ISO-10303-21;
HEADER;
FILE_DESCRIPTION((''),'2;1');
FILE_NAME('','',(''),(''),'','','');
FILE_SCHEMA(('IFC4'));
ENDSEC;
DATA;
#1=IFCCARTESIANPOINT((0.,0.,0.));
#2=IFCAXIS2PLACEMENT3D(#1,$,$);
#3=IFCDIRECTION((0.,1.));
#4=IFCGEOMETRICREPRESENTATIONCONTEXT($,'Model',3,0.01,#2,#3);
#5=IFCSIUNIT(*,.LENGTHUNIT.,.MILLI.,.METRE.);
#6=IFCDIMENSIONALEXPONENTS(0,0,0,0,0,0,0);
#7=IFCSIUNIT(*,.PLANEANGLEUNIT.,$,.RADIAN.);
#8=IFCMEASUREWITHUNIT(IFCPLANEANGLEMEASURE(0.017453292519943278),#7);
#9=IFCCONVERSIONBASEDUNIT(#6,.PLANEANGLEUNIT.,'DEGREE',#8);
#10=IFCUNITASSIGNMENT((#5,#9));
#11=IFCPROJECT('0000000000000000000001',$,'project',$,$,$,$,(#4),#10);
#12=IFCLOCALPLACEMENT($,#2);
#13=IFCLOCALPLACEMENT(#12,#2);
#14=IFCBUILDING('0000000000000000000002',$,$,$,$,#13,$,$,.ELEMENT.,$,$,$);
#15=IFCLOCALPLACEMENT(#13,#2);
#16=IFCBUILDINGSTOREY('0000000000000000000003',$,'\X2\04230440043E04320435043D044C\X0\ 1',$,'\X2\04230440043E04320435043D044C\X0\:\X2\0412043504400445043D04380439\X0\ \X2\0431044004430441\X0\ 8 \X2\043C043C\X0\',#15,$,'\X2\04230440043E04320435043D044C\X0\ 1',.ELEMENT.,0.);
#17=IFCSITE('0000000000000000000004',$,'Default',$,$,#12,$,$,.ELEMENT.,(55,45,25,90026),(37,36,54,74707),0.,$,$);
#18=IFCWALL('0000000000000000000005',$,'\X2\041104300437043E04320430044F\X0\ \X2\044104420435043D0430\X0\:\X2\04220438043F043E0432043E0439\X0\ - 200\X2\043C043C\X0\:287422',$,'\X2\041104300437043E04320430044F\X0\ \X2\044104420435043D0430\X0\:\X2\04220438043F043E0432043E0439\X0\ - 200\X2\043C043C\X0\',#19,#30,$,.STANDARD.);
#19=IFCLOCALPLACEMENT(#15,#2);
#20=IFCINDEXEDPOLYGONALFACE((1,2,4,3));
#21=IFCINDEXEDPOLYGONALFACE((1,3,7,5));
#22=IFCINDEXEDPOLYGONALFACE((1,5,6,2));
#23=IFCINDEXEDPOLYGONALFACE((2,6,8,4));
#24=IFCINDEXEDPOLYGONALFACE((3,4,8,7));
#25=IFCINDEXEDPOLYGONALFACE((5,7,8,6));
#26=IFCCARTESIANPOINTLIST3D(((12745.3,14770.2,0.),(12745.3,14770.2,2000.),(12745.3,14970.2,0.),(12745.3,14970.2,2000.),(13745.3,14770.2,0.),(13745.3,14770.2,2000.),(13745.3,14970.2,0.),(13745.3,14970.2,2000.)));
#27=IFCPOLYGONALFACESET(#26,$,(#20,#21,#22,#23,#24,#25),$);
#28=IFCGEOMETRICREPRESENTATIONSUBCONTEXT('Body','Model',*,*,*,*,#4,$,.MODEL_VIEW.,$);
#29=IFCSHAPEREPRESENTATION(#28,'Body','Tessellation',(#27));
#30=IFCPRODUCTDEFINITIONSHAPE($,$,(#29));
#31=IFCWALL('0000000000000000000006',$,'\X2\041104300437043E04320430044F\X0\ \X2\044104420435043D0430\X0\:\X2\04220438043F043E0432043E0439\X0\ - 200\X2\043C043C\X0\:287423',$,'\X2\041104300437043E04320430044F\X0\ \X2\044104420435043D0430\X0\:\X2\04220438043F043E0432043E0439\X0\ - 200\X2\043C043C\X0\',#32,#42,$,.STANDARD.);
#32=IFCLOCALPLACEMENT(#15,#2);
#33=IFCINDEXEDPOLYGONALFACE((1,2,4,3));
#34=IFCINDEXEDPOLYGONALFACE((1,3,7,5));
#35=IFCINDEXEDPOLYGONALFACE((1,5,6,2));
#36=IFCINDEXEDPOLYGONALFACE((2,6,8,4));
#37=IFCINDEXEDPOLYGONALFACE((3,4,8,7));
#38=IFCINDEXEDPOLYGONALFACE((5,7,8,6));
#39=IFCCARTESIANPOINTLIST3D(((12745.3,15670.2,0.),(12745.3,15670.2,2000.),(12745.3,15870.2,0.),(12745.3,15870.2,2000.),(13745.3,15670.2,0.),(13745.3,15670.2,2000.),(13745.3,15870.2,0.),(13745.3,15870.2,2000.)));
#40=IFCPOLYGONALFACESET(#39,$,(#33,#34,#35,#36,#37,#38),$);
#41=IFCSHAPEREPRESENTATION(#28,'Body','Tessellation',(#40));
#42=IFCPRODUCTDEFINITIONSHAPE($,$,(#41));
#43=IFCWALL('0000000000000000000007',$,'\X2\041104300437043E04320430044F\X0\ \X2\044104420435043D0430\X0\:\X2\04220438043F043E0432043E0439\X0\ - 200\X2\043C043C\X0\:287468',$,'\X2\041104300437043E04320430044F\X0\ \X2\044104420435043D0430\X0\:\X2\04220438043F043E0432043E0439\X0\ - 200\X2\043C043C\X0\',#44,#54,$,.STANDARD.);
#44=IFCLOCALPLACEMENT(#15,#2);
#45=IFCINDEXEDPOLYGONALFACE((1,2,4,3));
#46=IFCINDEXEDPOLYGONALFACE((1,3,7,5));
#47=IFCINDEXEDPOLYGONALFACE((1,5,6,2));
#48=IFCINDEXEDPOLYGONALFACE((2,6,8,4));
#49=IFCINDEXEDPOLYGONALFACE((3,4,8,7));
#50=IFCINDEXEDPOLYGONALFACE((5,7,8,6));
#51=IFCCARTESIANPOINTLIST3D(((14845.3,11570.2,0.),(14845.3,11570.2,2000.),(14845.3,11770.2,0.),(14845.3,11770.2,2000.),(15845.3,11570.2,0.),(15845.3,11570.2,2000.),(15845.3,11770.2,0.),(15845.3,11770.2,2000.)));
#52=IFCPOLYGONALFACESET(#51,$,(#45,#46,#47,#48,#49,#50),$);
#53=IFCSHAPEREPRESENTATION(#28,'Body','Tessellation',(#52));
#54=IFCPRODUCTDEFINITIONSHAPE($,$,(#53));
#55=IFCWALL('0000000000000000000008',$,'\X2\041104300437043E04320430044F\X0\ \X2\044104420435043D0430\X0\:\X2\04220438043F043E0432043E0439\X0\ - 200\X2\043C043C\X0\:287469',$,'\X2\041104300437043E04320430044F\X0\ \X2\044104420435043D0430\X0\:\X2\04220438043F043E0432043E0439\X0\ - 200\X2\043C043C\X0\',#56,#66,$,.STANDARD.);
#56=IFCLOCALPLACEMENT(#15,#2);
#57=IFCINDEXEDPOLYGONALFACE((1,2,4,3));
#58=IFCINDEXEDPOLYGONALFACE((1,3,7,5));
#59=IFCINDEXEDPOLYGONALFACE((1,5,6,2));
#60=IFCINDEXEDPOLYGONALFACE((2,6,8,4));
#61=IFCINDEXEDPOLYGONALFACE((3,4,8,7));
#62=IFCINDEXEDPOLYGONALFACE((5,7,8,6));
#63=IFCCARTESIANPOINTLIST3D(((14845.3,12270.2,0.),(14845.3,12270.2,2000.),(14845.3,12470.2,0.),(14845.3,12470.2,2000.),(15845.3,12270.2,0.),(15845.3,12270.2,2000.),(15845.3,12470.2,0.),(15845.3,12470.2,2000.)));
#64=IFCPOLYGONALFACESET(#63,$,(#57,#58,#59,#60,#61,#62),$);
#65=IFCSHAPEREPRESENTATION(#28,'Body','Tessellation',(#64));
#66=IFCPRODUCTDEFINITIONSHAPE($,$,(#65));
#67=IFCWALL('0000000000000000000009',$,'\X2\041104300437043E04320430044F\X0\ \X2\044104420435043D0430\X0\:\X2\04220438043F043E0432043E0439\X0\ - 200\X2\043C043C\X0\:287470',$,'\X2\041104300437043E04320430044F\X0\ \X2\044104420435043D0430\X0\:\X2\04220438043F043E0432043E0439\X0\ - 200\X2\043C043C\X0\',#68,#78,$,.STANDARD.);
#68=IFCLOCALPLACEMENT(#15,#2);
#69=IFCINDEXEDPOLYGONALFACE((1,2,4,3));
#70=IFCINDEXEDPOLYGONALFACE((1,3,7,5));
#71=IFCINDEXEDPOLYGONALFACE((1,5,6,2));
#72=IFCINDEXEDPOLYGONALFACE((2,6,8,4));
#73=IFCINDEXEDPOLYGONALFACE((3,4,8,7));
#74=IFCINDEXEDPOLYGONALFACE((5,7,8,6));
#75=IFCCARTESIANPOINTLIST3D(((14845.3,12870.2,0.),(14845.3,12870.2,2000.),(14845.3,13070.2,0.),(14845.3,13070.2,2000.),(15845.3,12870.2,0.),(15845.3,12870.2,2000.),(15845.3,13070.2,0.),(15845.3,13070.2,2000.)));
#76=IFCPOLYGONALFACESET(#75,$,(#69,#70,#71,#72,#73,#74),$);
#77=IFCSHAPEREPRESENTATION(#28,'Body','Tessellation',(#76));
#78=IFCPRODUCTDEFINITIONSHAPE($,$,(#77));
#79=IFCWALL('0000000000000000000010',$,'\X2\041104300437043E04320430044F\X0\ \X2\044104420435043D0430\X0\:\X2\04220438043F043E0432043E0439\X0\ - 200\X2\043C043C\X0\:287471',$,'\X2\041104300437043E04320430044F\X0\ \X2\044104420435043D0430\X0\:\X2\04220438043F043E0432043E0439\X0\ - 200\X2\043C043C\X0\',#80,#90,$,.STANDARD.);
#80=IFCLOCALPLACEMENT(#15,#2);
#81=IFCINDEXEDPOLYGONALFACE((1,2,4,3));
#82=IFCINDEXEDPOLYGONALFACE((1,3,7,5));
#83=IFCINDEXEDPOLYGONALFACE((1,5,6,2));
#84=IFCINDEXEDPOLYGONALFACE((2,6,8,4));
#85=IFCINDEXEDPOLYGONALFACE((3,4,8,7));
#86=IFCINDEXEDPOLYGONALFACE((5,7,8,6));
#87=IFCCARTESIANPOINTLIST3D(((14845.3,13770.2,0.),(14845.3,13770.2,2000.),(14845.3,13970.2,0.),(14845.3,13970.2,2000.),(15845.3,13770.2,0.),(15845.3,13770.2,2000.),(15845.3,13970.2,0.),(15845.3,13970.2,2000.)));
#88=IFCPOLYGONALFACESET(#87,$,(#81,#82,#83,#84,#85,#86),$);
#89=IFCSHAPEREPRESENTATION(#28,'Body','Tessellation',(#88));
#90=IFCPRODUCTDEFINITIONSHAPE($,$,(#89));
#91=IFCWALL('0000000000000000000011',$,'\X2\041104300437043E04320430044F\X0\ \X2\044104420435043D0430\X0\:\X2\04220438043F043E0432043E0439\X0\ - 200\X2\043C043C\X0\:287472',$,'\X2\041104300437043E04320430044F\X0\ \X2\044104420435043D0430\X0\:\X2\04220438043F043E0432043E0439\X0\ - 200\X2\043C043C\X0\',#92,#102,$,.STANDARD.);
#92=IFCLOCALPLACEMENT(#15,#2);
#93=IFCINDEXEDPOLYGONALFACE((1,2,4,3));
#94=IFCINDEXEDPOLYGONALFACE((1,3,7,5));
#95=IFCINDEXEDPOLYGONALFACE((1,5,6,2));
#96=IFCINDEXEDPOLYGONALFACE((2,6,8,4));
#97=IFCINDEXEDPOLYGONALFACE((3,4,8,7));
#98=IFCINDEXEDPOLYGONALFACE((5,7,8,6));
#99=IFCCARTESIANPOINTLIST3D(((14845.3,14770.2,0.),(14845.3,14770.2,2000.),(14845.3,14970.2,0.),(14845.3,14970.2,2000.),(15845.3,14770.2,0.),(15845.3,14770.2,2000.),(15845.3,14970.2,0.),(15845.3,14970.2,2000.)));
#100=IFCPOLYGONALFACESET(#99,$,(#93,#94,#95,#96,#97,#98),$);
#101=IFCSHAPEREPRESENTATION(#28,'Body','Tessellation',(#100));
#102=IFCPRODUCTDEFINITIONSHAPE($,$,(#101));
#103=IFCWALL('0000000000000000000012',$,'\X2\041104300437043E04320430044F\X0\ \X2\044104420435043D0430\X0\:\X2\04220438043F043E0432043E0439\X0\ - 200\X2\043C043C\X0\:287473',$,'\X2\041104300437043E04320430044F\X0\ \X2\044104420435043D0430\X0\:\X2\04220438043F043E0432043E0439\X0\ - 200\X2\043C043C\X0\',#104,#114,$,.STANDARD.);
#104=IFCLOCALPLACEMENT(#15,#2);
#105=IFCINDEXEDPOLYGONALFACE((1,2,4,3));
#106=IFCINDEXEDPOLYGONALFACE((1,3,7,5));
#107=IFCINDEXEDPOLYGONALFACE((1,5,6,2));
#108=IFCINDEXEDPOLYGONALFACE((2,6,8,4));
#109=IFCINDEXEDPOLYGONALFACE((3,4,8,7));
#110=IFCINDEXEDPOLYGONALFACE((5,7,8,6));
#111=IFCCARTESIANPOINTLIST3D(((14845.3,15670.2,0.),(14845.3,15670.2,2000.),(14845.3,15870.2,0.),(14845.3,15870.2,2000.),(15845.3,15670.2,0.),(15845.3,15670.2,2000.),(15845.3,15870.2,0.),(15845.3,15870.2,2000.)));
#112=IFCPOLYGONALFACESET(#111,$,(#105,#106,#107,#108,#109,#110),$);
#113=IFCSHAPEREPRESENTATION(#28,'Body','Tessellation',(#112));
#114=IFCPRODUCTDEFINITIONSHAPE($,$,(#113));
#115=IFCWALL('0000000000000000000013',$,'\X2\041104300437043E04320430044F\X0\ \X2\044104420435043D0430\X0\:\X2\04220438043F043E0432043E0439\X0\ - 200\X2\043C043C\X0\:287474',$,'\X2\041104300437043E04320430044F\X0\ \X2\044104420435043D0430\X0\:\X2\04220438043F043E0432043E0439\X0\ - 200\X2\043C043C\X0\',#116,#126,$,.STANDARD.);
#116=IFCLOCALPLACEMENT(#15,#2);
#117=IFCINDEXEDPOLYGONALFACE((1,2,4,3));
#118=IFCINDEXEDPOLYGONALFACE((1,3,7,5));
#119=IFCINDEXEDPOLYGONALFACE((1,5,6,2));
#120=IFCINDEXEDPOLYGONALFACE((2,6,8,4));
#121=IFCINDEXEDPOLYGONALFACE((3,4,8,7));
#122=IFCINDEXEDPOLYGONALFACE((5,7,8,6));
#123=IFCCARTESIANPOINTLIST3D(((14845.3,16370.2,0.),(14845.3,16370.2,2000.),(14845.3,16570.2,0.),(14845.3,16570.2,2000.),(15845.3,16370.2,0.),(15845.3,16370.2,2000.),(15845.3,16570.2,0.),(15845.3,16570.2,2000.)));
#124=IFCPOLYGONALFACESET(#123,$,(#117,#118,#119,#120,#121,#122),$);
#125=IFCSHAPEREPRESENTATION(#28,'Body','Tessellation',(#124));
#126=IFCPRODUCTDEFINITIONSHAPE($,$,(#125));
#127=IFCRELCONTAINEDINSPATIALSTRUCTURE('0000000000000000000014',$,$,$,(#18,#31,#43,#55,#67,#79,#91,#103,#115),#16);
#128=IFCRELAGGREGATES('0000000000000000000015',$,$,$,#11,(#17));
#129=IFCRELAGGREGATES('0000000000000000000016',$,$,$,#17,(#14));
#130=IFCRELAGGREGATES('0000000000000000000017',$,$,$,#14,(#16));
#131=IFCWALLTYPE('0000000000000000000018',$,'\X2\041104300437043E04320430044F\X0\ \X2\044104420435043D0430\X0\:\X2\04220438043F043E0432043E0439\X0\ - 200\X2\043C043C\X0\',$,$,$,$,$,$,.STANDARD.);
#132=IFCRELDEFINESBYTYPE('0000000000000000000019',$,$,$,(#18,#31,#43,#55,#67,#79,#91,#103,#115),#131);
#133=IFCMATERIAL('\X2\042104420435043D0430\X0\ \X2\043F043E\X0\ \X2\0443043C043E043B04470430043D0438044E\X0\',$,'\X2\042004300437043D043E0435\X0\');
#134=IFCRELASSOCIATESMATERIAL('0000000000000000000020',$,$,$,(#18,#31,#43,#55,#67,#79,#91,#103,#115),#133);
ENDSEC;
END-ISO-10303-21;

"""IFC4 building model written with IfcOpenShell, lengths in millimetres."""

from ifc_helpers import new_model, entity, si_unit, converted_unit, direction, frame, origin, place, context, subcontext, project, spatial, indexed_curve, outline, extrude, material, type_object, element, save


model = new_model("IFC4")

# Units and contexts
model_context = context("Model", 3, precision=0.01, world=origin(), true_north=direction((0.0, 1.0)))
body_context = subcontext(model_context, "Body", "Model", "MODEL_VIEW")
ifc_project = project(units=[si_unit("LENGTHUNIT", "METRE", prefix="MILLI"), converted_unit("PLANEANGLEUNIT", "DEGREE", entity("IfcPlaneAngleMeasure", 0.017453292519943278), si_unit("PLANEANGLEUNIT", "RADIAN"), dimensions=[0, 0, 0, 0, 0, 0, 0])], contexts=[model_context])

# Site, building, storey
site_placement = place(None, origin())
site = spatial("IfcSite", under=ifc_project, at=site_placement, Name="Default", CompositionType="ELEMENT", RefLatitude=(55, 45, 25, 90026), RefLongitude=(37, 36, 54, 74707), RefElevation=0.0)
building_placement = place(site_placement, origin())
building = spatial("IfcBuilding", under=site, at=building_placement, CompositionType="ELEMENT")
storey_placement = place(building_placement, origin())
storey = spatial("IfcBuildingStorey", under=building, at=storey_placement, Name="Уровень 1", ObjectType="Уровень:Верхний брус 8 мм", LongName="Уровень 1", CompositionType="ELEMENT", Elevation=0.0)

# Walls
ifc_material = material(Name="Стена по умолчанию", Category="Разное")
wall_type = type_object("IfcWallType", Name="Базовая стена:Типовой - 200мм", PredefinedType="STANDARD")
for number, where, name in (
    (1, (12745.3, 14870.2, 0.0), "Базовая стена:Типовой - 200мм:287422"),
    (2, (12745.3, 15770.2, 0.0), "Базовая стена:Типовой - 200мм:287423"),
):
    element("IfcWall", number, at=place(storey_placement, frame(where)), inside=storey, type_object=wall_type, material=ifc_material, Name=name, ObjectType="Базовая стена:Типовой - 200мм", PredefinedType="STANDARD", context=body_context, shape_type="SweptSolid", body=[
        extrude(outline(indexed_curve([(1000.0, 100.0), (0.0, 100.0), (0.0, -100.0), (1000.0, -100.0), (1000.0, 100.0)], self_intersect=False)), origin(), (0.0, 0.0, 1.0), 2000.0),
    ])
wall_1_placement = place(storey_placement, frame((14845.3, 11670.2, 0.0)))
element("IfcWall", 3, at=wall_1_placement, inside=storey, type_object=wall_type, material=ifc_material, Name="Базовая стена:Типовой - 200мм:287468", ObjectType="Базовая стена:Типовой - 200мм", PredefinedType="STANDARD", context=body_context, shape_type="SweptSolid", body=[
    extrude(outline(indexed_curve([(1000.0, 100.0), (0.0, 100.0), (0.0, -100.0), (1000.0, -100.0), (1000.0, 100.0)], self_intersect=False)), origin(), (0.0, 0.0, 1.0), 2000.0),
])
wall_2_placement = place(storey_placement, frame((14845.3, 12370.2, 0.0)))
element("IfcWall", 4, at=wall_2_placement, inside=storey, type_object=wall_type, material=ifc_material, Name="Базовая стена:Типовой - 200мм:287469", ObjectType="Базовая стена:Типовой - 200мм", PredefinedType="STANDARD", context=body_context, shape_type="SweptSolid", body=[
    extrude(outline(indexed_curve([(1000.0, 100.0), (0.0, 100.0), (0.0, -100.0), (1000.0, -100.0), (1000.0, 100.0)], self_intersect=False)), origin(), (0.0, 0.0, 1.0), 2000.0),
])
wall_3_placement = place(storey_placement, frame((14845.3, 12970.2, 0.0)))
element("IfcWall", 5, at=wall_3_placement, inside=storey, type_object=wall_type, material=ifc_material, Name="Базовая стена:Типовой - 200мм:287470", ObjectType="Базовая стена:Типовой - 200мм", PredefinedType="STANDARD", context=body_context, shape_type="SweptSolid", body=[
    extrude(outline(indexed_curve([(1000.0, 100.0), (0.0, 100.0), (0.0, -100.0), (1000.0, -100.0), (1000.0, 100.0)], self_intersect=False)), origin(), (0.0, 0.0, 1.0), 2000.0),
])
wall_4_placement = place(storey_placement, frame((14845.3, 13870.2, 0.0)))
element("IfcWall", 6, at=wall_4_placement, inside=storey, type_object=wall_type, material=ifc_material, Name="Базовая стена:Типовой - 200мм:287471", ObjectType="Базовая стена:Типовой - 200мм", PredefinedType="STANDARD", context=body_context, shape_type="SweptSolid", body=[
    extrude(outline(indexed_curve([(1000.0, 100.0), (0.0, 100.0), (0.0, -100.0), (1000.0, -100.0), (1000.0, 100.0)], self_intersect=False)), origin(), (0.0, 0.0, 1.0), 2000.0),
])
wall_5_placement = place(storey_placement, frame((14845.3, 14870.2, 0.0)))
element("IfcWall", 7, at=wall_5_placement, inside=storey, type_object=wall_type, material=ifc_material, Name="Базовая стена:Типовой - 200мм:287472", ObjectType="Базовая стена:Типовой - 200мм", PredefinedType="STANDARD", context=body_context, shape_type="SweptSolid", body=[
    extrude(outline(indexed_curve([(1000.0, 100.0), (0.0, 100.0), (0.0, -100.0), (1000.0, -100.0), (1000.0, 100.0)], self_intersect=False)), origin(), (0.0, 0.0, 1.0), 2000.0),
])
wall_6_placement = place(storey_placement, frame((14845.3, 15770.2, 0.0)))
element("IfcWall", 8, at=wall_6_placement, inside=storey, type_object=wall_type, material=ifc_material, Name="Базовая стена:Типовой - 200мм:287473", ObjectType="Базовая стена:Типовой - 200мм", PredefinedType="STANDARD", context=body_context, shape_type="SweptSolid", body=[
    extrude(outline(indexed_curve([(1000.0, 100.0), (0.0, 100.0), (0.0, -100.0), (1000.0, -100.0), (1000.0, 100.0)], self_intersect=False)), origin(), (0.0, 0.0, 1.0), 2000.0),
])
wall_7_placement = place(storey_placement, frame((14845.3, 16470.2, 0.0)))
element("IfcWall", 9, at=wall_7_placement, inside=storey, type_object=wall_type, material=ifc_material, Name="Базовая стена:Типовой - 200мм:287474", ObjectType="Базовая стена:Типовой - 200мм", PredefinedType="STANDARD", context=body_context, shape_type="SweptSolid", body=[
    extrude(outline(indexed_curve([(1000.0, 100.0), (0.0, 100.0), (0.0, -100.0), (1000.0, -100.0), (1000.0, 100.0)], self_intersect=False)), origin(), (0.0, 0.0, 1.0), 2000.0),
])

save(model, "model.ifc")
